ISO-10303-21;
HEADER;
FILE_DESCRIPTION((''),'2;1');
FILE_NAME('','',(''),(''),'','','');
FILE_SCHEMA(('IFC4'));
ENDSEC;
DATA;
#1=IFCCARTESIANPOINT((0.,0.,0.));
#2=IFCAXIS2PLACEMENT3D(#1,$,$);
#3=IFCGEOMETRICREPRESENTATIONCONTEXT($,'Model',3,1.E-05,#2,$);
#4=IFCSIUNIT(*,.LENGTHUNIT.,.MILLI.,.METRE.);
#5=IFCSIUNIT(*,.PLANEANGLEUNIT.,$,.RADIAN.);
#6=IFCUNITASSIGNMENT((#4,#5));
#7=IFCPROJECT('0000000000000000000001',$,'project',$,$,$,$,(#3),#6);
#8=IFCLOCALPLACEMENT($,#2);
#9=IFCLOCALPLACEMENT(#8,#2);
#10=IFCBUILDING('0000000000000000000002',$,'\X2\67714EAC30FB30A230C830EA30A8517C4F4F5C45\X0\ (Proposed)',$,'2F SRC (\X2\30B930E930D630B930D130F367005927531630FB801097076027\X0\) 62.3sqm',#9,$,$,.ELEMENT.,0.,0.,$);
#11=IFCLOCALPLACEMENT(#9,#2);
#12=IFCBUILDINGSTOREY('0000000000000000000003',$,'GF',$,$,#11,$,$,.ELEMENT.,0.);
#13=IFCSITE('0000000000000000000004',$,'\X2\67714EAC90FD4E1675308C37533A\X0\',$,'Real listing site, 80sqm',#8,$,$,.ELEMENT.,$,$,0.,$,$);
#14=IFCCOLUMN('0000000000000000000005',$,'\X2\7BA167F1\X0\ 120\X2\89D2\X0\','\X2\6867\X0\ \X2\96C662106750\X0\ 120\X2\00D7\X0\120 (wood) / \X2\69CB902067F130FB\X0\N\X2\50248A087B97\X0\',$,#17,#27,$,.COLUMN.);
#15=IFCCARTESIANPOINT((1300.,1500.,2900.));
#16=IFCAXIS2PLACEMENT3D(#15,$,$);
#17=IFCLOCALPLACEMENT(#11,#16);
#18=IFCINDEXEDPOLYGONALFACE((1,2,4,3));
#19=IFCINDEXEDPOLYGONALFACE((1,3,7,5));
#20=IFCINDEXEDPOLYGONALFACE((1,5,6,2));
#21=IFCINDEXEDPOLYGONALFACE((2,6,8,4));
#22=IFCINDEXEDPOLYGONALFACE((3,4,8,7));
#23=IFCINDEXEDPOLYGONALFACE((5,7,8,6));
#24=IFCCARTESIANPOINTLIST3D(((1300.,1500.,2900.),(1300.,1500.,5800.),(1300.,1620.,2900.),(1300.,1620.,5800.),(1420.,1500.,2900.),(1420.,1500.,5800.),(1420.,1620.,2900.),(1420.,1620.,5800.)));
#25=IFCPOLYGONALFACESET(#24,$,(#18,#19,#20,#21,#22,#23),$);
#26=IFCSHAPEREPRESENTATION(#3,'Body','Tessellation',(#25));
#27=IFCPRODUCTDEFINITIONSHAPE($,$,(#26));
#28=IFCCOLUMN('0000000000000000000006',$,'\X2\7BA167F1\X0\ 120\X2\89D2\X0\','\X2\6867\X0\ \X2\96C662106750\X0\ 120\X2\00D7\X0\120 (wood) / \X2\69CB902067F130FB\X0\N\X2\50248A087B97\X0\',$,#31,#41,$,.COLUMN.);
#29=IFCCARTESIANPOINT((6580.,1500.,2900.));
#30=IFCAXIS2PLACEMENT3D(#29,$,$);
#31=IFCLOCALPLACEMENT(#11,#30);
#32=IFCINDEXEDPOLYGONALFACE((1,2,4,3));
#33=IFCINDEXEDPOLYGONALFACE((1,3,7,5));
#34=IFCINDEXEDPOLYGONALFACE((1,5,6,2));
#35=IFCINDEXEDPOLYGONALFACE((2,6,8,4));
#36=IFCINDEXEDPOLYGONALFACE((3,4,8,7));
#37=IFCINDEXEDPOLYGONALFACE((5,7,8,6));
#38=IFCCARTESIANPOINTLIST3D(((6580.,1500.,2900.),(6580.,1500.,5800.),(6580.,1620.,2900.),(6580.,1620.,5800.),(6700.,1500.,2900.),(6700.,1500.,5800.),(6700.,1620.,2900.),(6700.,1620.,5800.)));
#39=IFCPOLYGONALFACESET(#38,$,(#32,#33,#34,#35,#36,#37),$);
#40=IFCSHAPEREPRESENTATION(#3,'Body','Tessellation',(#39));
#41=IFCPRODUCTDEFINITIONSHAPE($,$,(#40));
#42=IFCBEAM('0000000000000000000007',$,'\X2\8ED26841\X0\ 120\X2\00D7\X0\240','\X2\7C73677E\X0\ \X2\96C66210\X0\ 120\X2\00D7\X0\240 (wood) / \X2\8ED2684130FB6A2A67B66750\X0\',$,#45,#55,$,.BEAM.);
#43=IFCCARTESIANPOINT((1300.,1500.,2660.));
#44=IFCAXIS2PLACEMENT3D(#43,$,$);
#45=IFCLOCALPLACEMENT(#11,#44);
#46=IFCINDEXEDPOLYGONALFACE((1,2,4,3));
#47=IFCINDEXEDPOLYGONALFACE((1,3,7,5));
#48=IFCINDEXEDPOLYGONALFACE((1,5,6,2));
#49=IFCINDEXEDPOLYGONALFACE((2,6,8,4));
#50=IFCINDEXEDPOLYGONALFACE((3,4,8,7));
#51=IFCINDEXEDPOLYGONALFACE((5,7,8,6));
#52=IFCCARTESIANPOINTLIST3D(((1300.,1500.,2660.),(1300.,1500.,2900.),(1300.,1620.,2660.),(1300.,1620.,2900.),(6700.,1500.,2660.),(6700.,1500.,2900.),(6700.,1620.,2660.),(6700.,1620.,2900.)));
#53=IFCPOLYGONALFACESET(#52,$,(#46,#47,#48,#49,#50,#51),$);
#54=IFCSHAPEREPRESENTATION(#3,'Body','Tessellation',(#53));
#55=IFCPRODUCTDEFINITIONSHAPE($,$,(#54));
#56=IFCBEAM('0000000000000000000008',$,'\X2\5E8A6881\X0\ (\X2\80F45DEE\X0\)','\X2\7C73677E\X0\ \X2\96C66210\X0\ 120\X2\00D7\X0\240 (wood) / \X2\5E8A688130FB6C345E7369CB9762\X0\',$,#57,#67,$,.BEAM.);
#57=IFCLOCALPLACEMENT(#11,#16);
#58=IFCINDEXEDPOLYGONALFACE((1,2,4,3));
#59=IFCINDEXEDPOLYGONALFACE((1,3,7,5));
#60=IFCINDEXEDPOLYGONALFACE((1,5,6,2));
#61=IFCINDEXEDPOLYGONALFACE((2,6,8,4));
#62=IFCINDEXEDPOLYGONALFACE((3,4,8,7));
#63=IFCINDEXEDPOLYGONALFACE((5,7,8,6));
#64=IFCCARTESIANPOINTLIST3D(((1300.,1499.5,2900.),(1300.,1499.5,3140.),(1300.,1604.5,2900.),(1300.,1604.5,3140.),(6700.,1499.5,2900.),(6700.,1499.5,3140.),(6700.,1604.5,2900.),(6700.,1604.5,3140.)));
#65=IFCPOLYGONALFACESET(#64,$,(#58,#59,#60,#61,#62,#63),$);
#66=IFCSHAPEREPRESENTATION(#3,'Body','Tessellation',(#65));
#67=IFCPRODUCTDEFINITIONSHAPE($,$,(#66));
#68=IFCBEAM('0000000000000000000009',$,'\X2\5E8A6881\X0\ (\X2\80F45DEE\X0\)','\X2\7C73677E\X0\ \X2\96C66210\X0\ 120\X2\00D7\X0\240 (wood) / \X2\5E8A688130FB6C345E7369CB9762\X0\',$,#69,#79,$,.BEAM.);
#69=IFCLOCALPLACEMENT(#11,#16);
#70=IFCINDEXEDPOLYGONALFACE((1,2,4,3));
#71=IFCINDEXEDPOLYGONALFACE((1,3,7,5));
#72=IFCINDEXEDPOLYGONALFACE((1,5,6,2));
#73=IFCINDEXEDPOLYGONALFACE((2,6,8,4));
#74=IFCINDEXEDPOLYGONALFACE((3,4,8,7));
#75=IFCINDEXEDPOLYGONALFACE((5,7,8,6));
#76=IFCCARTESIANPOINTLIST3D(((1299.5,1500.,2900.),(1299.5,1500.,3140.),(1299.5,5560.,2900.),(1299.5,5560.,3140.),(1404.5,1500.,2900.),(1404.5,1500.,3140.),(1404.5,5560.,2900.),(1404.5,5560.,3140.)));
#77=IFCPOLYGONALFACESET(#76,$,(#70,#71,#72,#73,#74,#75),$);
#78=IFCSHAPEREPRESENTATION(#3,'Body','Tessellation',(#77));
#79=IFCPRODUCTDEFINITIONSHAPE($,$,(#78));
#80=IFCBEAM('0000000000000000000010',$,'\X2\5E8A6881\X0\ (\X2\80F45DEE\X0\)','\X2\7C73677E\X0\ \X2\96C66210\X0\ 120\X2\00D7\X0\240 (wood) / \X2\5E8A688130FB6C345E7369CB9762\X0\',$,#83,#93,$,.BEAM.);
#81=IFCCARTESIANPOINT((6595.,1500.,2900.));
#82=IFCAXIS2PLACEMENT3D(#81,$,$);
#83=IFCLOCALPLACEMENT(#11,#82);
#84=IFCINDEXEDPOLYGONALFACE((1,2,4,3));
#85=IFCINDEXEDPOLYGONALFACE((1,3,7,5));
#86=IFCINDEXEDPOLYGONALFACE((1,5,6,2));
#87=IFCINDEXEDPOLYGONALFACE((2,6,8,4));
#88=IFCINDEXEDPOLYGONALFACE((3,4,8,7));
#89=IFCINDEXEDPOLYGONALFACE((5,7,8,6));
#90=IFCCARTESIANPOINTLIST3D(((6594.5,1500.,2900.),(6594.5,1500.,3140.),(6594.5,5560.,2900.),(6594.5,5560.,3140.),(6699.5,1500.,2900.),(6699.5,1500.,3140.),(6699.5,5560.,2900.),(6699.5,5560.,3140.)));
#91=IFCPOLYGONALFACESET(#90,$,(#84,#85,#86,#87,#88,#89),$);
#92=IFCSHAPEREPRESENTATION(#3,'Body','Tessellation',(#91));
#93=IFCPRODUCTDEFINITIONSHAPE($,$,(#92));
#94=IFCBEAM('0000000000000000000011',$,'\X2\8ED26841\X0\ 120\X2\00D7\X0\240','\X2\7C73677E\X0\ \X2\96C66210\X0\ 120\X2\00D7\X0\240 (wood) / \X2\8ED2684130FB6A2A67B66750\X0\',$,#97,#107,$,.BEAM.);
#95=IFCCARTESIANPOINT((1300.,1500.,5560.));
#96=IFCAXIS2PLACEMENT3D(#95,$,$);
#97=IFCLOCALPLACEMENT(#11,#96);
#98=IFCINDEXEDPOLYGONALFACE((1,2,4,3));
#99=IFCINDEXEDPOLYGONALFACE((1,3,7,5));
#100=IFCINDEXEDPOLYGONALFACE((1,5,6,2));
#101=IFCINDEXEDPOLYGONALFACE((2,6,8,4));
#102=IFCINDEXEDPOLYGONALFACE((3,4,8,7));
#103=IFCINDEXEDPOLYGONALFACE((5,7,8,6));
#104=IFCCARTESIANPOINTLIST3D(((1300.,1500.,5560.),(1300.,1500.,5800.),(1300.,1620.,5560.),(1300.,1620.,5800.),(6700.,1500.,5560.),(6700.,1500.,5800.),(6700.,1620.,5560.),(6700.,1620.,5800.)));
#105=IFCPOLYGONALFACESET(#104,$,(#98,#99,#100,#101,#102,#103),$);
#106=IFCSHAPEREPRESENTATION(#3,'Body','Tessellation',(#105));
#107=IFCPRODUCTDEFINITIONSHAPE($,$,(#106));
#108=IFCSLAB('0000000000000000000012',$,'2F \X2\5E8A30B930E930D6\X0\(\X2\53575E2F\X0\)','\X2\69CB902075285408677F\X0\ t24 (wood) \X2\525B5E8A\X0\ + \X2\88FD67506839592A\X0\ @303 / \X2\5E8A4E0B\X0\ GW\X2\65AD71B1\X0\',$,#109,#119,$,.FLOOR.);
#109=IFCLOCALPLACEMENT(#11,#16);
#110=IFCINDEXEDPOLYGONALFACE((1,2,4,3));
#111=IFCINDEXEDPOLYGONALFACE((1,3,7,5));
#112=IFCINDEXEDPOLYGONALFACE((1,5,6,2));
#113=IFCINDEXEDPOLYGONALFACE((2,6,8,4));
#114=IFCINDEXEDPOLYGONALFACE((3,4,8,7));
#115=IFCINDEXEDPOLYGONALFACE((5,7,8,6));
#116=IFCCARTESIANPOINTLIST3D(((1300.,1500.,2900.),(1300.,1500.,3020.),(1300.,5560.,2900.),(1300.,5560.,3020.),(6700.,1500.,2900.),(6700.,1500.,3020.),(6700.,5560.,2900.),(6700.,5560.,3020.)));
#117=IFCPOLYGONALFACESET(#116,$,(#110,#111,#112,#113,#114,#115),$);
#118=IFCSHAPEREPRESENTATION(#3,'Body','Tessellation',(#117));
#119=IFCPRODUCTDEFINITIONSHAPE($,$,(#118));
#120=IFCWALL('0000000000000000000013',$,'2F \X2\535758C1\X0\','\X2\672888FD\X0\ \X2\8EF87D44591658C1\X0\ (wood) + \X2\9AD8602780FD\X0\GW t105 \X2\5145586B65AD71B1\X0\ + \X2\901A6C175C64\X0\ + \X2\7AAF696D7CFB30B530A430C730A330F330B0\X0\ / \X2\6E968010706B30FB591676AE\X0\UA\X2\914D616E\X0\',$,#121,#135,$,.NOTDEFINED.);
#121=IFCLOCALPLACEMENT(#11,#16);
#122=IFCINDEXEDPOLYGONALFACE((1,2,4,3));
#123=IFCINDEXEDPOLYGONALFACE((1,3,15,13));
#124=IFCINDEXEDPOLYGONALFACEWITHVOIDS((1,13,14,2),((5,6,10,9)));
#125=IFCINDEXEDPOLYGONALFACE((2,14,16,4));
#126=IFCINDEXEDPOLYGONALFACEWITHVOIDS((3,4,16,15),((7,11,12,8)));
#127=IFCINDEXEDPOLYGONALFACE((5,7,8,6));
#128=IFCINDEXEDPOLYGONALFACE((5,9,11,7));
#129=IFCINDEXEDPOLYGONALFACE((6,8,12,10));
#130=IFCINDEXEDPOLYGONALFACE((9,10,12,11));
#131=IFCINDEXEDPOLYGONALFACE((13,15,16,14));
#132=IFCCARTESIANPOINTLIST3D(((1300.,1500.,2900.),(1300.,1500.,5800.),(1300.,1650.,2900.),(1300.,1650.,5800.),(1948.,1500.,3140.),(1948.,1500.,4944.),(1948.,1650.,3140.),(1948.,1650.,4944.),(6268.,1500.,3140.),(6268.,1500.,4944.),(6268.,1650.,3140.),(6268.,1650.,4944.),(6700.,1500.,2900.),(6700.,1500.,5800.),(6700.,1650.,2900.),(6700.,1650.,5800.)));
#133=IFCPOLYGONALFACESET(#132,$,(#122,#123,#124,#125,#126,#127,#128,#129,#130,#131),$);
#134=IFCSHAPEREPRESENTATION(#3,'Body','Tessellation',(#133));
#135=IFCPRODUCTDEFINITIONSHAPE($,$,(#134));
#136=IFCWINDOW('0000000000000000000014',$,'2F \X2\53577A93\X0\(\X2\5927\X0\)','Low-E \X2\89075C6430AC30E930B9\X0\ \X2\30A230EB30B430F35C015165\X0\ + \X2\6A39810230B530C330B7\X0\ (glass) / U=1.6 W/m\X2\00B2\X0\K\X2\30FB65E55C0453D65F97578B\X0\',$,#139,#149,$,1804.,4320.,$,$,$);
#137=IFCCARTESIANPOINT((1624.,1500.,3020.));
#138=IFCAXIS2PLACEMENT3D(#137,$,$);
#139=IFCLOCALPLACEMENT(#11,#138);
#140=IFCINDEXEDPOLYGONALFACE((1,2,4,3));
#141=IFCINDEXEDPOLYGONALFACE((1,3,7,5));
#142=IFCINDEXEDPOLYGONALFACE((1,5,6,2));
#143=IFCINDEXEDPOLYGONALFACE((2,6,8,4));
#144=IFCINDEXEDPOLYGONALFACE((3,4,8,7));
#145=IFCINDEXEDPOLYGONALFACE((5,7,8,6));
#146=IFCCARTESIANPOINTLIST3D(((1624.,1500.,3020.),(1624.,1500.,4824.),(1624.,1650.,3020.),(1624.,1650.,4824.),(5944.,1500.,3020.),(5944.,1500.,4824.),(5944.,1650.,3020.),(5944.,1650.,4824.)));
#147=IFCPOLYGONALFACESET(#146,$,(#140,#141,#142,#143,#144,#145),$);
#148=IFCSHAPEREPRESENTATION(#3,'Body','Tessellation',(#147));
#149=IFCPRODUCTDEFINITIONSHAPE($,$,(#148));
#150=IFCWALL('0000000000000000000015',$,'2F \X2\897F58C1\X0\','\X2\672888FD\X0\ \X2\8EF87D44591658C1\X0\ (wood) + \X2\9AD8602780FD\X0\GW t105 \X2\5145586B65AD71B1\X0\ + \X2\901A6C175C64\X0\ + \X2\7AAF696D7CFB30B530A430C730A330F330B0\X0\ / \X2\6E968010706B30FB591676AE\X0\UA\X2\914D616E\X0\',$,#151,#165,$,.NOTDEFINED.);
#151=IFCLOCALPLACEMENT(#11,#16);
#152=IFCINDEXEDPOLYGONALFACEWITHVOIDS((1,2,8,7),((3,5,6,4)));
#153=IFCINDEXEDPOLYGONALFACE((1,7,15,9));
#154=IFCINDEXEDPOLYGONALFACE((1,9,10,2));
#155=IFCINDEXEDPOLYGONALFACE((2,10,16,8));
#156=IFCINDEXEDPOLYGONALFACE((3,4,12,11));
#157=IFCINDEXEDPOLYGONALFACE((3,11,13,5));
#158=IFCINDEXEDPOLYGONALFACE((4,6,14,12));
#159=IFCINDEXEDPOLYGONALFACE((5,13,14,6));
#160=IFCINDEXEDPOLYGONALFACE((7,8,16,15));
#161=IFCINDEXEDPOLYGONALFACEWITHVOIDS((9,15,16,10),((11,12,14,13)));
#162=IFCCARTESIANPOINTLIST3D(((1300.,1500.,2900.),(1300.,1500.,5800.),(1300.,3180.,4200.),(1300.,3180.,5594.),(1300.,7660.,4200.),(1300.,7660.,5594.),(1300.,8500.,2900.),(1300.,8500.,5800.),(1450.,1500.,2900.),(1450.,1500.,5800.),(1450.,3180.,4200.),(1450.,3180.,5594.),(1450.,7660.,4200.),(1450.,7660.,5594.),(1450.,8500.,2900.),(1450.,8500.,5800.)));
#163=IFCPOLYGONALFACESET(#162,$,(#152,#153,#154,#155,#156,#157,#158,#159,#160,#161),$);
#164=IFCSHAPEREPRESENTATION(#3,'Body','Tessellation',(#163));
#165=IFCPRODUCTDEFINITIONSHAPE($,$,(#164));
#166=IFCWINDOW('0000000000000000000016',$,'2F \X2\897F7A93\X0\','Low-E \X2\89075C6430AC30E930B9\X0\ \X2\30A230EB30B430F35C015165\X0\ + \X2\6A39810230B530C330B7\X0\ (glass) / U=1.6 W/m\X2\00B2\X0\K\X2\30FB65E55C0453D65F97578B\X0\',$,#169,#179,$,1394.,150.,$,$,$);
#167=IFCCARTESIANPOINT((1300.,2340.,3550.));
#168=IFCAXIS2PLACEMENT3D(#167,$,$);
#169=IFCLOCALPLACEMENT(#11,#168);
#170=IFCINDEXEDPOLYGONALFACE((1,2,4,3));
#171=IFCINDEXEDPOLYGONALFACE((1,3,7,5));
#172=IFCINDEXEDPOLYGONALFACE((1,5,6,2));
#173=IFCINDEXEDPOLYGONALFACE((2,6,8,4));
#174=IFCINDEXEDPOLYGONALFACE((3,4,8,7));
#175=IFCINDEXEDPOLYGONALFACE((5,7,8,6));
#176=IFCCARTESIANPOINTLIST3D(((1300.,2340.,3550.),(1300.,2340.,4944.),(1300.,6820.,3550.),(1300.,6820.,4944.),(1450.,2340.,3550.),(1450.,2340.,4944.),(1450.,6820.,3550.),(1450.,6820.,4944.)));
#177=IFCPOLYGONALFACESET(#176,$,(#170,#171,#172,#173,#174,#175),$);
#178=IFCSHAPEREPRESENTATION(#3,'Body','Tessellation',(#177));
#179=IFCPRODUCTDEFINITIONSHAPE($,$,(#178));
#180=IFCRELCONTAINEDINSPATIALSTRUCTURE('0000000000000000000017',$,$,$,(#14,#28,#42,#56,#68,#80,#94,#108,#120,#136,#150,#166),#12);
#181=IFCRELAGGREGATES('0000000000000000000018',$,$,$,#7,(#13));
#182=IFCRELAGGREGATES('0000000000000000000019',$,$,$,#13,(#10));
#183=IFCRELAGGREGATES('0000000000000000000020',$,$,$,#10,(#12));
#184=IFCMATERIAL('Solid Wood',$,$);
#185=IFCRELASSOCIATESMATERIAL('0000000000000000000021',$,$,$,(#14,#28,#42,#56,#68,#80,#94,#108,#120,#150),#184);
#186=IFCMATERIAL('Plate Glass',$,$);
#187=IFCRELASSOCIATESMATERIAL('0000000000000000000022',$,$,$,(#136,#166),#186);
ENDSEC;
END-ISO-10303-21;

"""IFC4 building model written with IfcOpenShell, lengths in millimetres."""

from ifc_helpers import new_model, si_unit, frame, frame_2d, origin, place, context, project, spatial, rectangle, extrude, material, element, fill, save


model = new_model("IFC4")

# Units and contexts
model_context = context("Model", 3, precision=1e-05, world=origin())
ifc_project = project(units=[si_unit("LENGTHUNIT", "METRE", prefix="MILLI"), si_unit("PLANEANGLEUNIT", "RADIAN")], contexts=[model_context])

# Site, building, storey
site_placement = place(None, origin())
site = spatial("IfcSite", under=ifc_project, at=site_placement, Name="東京都世田谷区", ObjectType="Real listing site, 80sqm", CompositionType="ELEMENT", RefElevation=0.0)
building_placement = place(site_placement, origin())
building = spatial("IfcBuilding", under=site, at=building_placement, Name="東京・アトリエ兼住居 (Proposed)", ObjectType="2F SRC (スラブスパン最大化・耐震性) 62.3sqm", CompositionType="ELEMENT", ElevationOfRefHeight=0.0, ElevationOfTerrain=0.0)
storey_placement = place(building_placement, origin())
storey = spatial("IfcBuildingStorey", under=building, at=storey_placement, Name="GF", CompositionType="ELEMENT", Elevation=0.0)

# Columns
ifc_material_1 = material(Name="Solid Wood")
column_1_placement = place(storey_placement, frame((1300.0, 1500.0, 2900.0)))
element("IfcColumn", 1, at=column_1_placement, inside=storey, material=ifc_material_1, Name="管柱 120角", Description="桧 集成材 120×120 (wood) / 構造柱・N値計算", PredefinedType="COLUMN", context=model_context, shape_type="SweptSolid", body=[
    extrude(rectangle(XDim=120.0, YDim=120.0, at=frame_2d((60.0, 60.0))), frame((1300.0, 1500.0, 2900.0)), (0.0, 0.0, 1.0), 2900.0),
])
column_2_placement = place(storey_placement, frame((6580.0, 1500.0, 2900.0)))
element("IfcColumn", 2, at=column_2_placement, inside=storey, material=ifc_material_1, Name="管柱 120角", Description="桧 集成材 120×120 (wood) / 構造柱・N値計算", PredefinedType="COLUMN", context=model_context, shape_type="SweptSolid", body=[
    extrude(rectangle(XDim=120.0, YDim=120.0, at=frame_2d((60.0, 60.0))), frame((6580.0, 1500.0, 2900.0)), (0.0, 0.0, 1.0), 2900.0),
])

# Beams
beam_1_placement = place(storey_placement, frame((1300.0, 1500.0, 2660.0)))
element("IfcBeam", 3, at=beam_1_placement, inside=storey, material=ifc_material_1, Name="軒桁 120×240", Description="米松 集成 120×240 (wood) / 軒桁・横架材", PredefinedType="BEAM", context=model_context, shape_type="SweptSolid", body=[
    extrude(rectangle(XDim=5400.0, YDim=120.0, at=frame_2d((2700.0, 60.0))), frame((1300.0, 1500.0, 2660.0)), (0.0, 0.0, 1.0), 240.0),
])
beam_2_placement = place(storey_placement, frame((1300.0, 1500.0, 2900.0)))
element("IfcBeam", 4, at=beam_2_placement, inside=storey, material=ifc_material_1, Name="床梁 (胴差)", Description="米松 集成 120×240 (wood) / 床梁・水平構面", PredefinedType="BEAM", context=model_context, shape_type="SweptSolid", body=[
    extrude(rectangle(XDim=5400.0, YDim=105.0, at=frame_2d((2700.0, 52.0))), frame((1300.0, 1500.0, 2900.0)), (0.0, 0.0, 1.0), 240.0),
])
beam_3_placement = place(storey_placement, frame((1300.0, 1500.0, 2900.0)))
element("IfcBeam", 5, at=beam_3_placement, inside=storey, material=ifc_material_1, Name="床梁 (胴差)", Description="米松 集成 120×240 (wood) / 床梁・水平構面", PredefinedType="BEAM", context=model_context, shape_type="SweptSolid", body=[
    extrude(rectangle(XDim=105.0, YDim=4060.0, at=frame_2d((52.0, 2030.0))), frame((1300.0, 1500.0, 2900.0)), (0.0, 0.0, 1.0), 240.0),
])
beam_4_placement = place(storey_placement, frame((6595.0, 1500.0, 2900.0)))
element("IfcBeam", 6, at=beam_4_placement, inside=storey, material=ifc_material_1, Name="床梁 (胴差)", Description="米松 集成 120×240 (wood) / 床梁・水平構面", PredefinedType="BEAM", context=model_context, shape_type="SweptSolid", body=[
    extrude(rectangle(XDim=105.0, YDim=4060.0, at=frame_2d((52.0, 2030.0))), frame((6595.0, 1500.0, 2900.0)), (0.0, 0.0, 1.0), 240.0),
])
beam_5_placement = place(storey_placement, frame((1300.0, 1500.0, 5560.0)))
element("IfcBeam", 7, at=beam_5_placement, inside=storey, material=ifc_material_1, Name="軒桁 120×240", Description="米松 集成 120×240 (wood) / 軒桁・横架材", PredefinedType="BEAM", context=model_context, shape_type="SweptSolid", body=[
    extrude(rectangle(XDim=5400.0, YDim=120.0, at=frame_2d((2700.0, 60.0))), frame((1300.0, 1500.0, 5560.0)), (0.0, 0.0, 1.0), 240.0),
])

# Slab
slab_placement = place(storey_placement, frame((1300.0, 1500.0, 2900.0)))
element("IfcSlab", 8, at=slab_placement, inside=storey, material=ifc_material_1, Name="2F 床スラブ(南帯)", Description="構造用合板 t24 (wood) 剛床 + 製材根太 @303 / 床下 GW断熱", PredefinedType="FLOOR", context=model_context, shape_type="SweptSolid", body=[
    extrude(rectangle(XDim=5400.0, YDim=4060.0, at=frame_2d((2700.0, 2030.0))), frame((1300.0, 1500.0, 2900.0)), (0.0, 0.0, 1.0), 120.0),
])

# Walls, openings, windows
wall_1_placement = place(storey_placement, frame((1300.0, 1500.0, 2900.0)))
wall_1 = element("IfcWall", 9, at=wall_1_placement, inside=storey, material=ifc_material_1, Name="2F 南壁", Description="木製 軸組外壁 (wood) + 高性能GW t105 充填断熱 + 通気層 + 窯業系サイディング / 準耐火・外皮UA配慮", PredefinedType="NOTDEFINED", context=model_context, shape_type="SweptSolid", body=[
    extrude(rectangle(XDim=5400.0, YDim=150.0, at=frame_2d((2700.0, 75.0))), frame((1300.0, 1500.0, 2900.0)), (0.0, 0.0, 1.0), 2900.0),
])
opening_1_placement = place(storey_placement, frame((1624.0, 1500.0, 3020.0)))
opening_1 = element("IfcOpeningElement", 10, at=opening_1_placement, cuts=wall_1, PredefinedType="NOTDEFINED", context=model_context, shape_type="SweptSolid", body=[
    extrude(rectangle(XDim=4320.0, YDim=150.0, at=frame_2d((2160.0, 75.0))), frame((1624.0, 1500.0, 3020.0)), (0.0, 0.0, 1.0), 1804.0),
])
ifc_material_2 = material(Name="Plate Glass")
window_1_placement = place(storey_placement, frame((1624.0, 1500.0, 3020.0)))
window_1 = element("IfcWindow", 11, at=window_1_placement, inside=storey, material=ifc_material_2, Name="2F 南窓(大)", Description="Low-E 複層ガラス アルゴン封入 + 樹脂サッシ (glass) / U=1.6 W/m²K・日射取得型", OverallHeight=1804.0, OverallWidth=4320.0, context=model_context, shape_type="SweptSolid", body=[
    extrude(rectangle(XDim=4320.0, YDim=150.0, at=frame_2d((2160.0, 75.0))), frame((1624.0, 1500.0, 3020.0)), (0.0, 0.0, 1.0), 1804.0),
])
fill(opening_1, window_1)
wall_2_placement = place(storey_placement, frame((1300.0, 1500.0, 2900.0)))
wall_2 = element("IfcWall", 12, at=wall_2_placement, inside=storey, material=ifc_material_1, Name="2F 西壁", Description="木製 軸組外壁 (wood) + 高性能GW t105 充填断熱 + 通気層 + 窯業系サイディング / 準耐火・外皮UA配慮", PredefinedType="NOTDEFINED", context=model_context, shape_type="SweptSolid", body=[
    extrude(rectangle(XDim=150.0, YDim=7000.0, at=frame_2d((75.0, 3500.0))), frame((1300.0, 1500.0, 2900.0)), (0.0, 0.0, 1.0), 2900.0),
])
opening_2_placement = place(storey_placement, frame((1300.0, 2340.0, 3550.0)))
opening_2 = element("IfcOpeningElement", 13, at=opening_2_placement, cuts=wall_2, PredefinedType="NOTDEFINED", context=model_context, shape_type="SweptSolid", body=[
    extrude(rectangle(XDim=150.0, YDim=4480.0, at=frame_2d((75.0, 2240.0))), frame((1300.0, 2340.0, 3550.0)), (0.0, 0.0, 1.0), 1394.0),
])
window_2_placement = place(storey_placement, frame((1300.0, 2340.0, 3550.0)))
window_2 = element("IfcWindow", 14, at=window_2_placement, inside=storey, material=ifc_material_2, Name="2F 西窓", Description="Low-E 複層ガラス アルゴン封入 + 樹脂サッシ (glass) / U=1.6 W/m²K・日射取得型", OverallHeight=1394.0, OverallWidth=150.0, context=model_context, shape_type="SweptSolid", body=[
    extrude(rectangle(XDim=150.0, YDim=4480.0, at=frame_2d((75.0, 2240.0))), frame((1300.0, 2340.0, 3550.0)), (0.0, 0.0, 1.0), 1394.0),
])
fill(opening_2, window_2)

save(model, "model.ifc")
